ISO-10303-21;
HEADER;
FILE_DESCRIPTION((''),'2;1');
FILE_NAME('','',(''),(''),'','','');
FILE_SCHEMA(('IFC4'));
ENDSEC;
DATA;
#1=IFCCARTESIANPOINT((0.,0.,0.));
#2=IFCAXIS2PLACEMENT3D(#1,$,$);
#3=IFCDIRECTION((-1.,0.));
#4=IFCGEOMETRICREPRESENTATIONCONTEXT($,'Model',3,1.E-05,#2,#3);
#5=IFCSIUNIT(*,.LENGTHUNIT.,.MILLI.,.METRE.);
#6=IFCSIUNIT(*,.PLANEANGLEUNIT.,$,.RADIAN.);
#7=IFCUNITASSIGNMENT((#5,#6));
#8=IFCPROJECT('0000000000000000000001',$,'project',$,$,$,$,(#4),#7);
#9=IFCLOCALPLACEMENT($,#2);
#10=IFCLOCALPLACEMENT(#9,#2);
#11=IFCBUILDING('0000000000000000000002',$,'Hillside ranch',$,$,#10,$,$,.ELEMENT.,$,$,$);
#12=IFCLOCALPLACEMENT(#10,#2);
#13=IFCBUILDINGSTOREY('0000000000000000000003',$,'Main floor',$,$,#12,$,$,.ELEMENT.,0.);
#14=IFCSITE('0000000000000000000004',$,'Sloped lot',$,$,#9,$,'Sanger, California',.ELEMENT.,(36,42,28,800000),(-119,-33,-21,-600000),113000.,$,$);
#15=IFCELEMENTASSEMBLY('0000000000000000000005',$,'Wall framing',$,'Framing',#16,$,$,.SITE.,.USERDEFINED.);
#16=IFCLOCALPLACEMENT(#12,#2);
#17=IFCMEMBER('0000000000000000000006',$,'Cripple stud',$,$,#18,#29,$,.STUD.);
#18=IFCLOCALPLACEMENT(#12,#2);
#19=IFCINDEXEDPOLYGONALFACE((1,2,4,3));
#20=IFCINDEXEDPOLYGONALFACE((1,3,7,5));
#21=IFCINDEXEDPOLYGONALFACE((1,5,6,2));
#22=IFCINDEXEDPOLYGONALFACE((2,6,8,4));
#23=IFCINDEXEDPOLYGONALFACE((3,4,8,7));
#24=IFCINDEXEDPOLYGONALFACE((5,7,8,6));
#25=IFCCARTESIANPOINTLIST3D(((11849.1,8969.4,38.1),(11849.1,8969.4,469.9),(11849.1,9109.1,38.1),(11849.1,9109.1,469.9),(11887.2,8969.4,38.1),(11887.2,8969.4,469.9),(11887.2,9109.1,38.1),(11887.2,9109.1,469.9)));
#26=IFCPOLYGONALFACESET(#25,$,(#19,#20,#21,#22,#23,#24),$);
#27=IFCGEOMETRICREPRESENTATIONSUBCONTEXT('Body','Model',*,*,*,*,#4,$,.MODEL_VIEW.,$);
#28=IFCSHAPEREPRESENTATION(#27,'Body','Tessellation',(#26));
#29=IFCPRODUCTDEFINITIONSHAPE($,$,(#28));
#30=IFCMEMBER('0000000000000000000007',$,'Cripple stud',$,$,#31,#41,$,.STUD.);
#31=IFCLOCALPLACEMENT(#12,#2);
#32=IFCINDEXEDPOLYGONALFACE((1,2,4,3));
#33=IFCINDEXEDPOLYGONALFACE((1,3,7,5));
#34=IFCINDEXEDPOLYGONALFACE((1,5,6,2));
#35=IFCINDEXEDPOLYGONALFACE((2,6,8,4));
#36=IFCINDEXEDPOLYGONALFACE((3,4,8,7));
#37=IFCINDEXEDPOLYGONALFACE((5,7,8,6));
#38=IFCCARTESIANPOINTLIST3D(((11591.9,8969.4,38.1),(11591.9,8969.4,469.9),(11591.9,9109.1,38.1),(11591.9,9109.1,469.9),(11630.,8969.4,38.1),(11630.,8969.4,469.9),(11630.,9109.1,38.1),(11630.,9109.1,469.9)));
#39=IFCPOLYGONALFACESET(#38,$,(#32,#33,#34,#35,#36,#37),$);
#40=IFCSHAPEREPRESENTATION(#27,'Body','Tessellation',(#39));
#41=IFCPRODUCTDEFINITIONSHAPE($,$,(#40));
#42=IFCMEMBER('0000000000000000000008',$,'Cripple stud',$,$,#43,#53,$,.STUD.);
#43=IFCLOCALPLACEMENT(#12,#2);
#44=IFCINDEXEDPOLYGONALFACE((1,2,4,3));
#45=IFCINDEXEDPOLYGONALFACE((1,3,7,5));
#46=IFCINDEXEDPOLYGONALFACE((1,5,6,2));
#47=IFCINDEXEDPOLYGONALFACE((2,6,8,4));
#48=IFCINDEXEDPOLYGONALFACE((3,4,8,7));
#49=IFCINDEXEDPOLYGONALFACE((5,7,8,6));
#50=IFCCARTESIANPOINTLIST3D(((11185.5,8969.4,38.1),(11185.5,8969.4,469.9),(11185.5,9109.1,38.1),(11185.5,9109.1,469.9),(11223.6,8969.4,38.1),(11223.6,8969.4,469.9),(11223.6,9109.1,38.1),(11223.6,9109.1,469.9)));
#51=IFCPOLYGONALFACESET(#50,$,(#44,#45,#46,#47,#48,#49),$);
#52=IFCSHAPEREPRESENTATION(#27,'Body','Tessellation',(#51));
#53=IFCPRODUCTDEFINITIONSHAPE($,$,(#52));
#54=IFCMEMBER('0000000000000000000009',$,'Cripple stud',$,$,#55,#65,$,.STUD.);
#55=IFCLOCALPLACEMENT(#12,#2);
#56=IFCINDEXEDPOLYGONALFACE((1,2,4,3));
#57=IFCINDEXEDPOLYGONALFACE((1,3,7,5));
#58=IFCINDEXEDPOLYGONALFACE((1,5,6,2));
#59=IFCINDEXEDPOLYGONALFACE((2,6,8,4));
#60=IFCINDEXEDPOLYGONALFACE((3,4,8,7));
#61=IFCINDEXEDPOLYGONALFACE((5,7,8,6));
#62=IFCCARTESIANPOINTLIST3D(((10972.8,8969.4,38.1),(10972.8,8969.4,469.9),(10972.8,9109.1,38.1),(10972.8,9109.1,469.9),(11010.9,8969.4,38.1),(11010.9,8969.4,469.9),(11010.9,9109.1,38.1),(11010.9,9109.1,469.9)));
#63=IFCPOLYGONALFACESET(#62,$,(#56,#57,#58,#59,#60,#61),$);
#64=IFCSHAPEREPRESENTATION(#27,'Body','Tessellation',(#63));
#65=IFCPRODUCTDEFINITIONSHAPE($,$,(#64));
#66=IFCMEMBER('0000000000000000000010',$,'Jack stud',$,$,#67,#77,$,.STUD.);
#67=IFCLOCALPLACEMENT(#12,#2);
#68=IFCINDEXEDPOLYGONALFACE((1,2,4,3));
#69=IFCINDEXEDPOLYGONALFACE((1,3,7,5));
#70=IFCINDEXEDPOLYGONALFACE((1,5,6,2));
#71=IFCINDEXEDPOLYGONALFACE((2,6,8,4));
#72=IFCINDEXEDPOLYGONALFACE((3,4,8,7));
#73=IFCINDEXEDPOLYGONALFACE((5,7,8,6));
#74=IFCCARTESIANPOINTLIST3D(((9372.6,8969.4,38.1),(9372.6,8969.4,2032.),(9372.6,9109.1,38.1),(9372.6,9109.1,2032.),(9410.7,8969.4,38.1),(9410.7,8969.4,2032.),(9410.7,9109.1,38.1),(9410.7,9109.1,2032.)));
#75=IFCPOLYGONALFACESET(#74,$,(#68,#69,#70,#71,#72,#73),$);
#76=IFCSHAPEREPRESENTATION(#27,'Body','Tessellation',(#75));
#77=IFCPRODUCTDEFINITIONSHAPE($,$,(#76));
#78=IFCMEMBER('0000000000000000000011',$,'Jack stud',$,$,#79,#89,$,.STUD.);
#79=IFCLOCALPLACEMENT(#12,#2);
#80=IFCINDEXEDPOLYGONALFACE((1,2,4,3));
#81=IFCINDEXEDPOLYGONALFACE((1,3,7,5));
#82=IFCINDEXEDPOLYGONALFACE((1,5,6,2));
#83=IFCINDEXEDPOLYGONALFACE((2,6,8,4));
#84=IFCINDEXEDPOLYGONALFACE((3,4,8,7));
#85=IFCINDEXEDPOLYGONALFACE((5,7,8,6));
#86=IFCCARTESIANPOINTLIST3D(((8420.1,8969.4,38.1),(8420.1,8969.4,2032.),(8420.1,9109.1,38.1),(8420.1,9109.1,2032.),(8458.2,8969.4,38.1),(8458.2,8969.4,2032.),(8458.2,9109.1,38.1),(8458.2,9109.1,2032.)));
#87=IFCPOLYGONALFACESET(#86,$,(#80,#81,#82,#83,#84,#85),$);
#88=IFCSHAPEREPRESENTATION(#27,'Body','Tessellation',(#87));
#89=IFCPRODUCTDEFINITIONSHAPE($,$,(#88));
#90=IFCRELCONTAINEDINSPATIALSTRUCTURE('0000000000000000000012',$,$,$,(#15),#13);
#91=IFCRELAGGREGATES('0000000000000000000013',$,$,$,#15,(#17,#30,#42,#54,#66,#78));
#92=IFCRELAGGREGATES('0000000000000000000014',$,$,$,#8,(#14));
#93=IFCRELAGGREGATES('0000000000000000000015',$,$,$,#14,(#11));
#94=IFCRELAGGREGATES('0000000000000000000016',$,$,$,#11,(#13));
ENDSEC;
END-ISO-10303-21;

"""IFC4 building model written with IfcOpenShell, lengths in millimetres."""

from ifc_helpers import new_model, si_unit, direction, frame, origin, origin_with_axes, place, context, subcontext, project, spatial, polyline, outline, extrude, element, aggregate, save


model = new_model("IFC4")

# Units and contexts
model_context = context("Model", 3, precision=1e-05, world=origin(), true_north=direction((-1.0, 0.0)))
body_context = subcontext(model_context, "Body", "Model", "MODEL_VIEW")
ifc_project = project(units=[si_unit("LENGTHUNIT", "METRE", prefix="MILLI"), si_unit("PLANEANGLEUNIT", "RADIAN")], contexts=[model_context])

# Site, building, storey
site_placement = place(None, origin())
site = spatial("IfcSite", under=ifc_project, at=site_placement, Name="Sloped lot", LongName="Sanger, California", CompositionType="ELEMENT", RefLatitude=(36, 42, 28, 800000), RefLongitude=(-119, -33, -21, -600000), RefElevation=113000.0)
building_placement = place(site_placement, origin())
building = spatial("IfcBuilding", under=site, at=building_placement, Name="Hillside ranch", CompositionType="ELEMENT")
storey_placement = place(building_placement, origin())
storey = spatial("IfcBuildingStorey", under=building, at=storey_placement, Name="Main floor", CompositionType="ELEMENT", Elevation=0.0)

# Element assembly, members
assembly_placement = place(storey_placement, origin_with_axes())
assembly = element("IfcElementAssembly", 1, at=assembly_placement, inside=storey, Name="Wall framing", ObjectType="Framing", AssemblyPlace="SITE", PredefinedType="USERDEFINED")
member_1_placement = place(storey_placement, origin_with_axes())
member_1 = element("IfcMember", 2, at=member_1_placement, Name="Cripple stud", PredefinedType="STUD", context=body_context, shape_type="SweptSolid", body=[
    extrude(outline(polyline([(0.0, 0.0), (38.1, 0.0), (38.1, 139.7), (0.0, 139.7), (0.0, 0.0)])), frame((11887.2, 9109.1, 38.1), z_axis=(0.0, 0.0, 1.0), x_axis=(-1.0, 0.0, 0.0)), (0.0, 0.0, 1.0), 431.8),
])
member_2_placement = place(storey_placement, origin_with_axes())
member_2 = element("IfcMember", 3, at=member_2_placement, Name="Cripple stud", PredefinedType="STUD", context=body_context, shape_type="SweptSolid", body=[
    extrude(outline(polyline([(0.0, 0.0), (38.1, 0.0), (38.1, 139.7), (0.0, 139.7), (0.0, 0.0)])), frame((11630.0, 9109.1, 38.1), z_axis=(0.0, 0.0, 1.0), x_axis=(-1.0, 0.0, 0.0)), (0.0, 0.0, 1.0), 431.8),
])
member_3_placement = place(storey_placement, origin_with_axes())
member_3 = element("IfcMember", 4, at=member_3_placement, Name="Cripple stud", PredefinedType="STUD", context=body_context, shape_type="SweptSolid", body=[
    extrude(outline(polyline([(0.0, 0.0), (38.1, 0.0), (38.1, 139.7), (0.0, 139.7), (0.0, 0.0)])), frame((11223.6, 9109.1, 38.1), z_axis=(0.0, 0.0, 1.0), x_axis=(-1.0, 0.0, 0.0)), (0.0, 0.0, 1.0), 431.8),
])
member_4_placement = place(storey_placement, origin_with_axes())
member_4 = element("IfcMember", 5, at=member_4_placement, Name="Cripple stud", PredefinedType="STUD", context=body_context, shape_type="SweptSolid", body=[
    extrude(outline(polyline([(0.0, 0.0), (38.1, 0.0), (38.1, 139.7), (0.0, 139.7), (0.0, 0.0)])), frame((11010.9, 9109.1, 38.1), z_axis=(0.0, 0.0, 1.0), x_axis=(-1.0, 0.0, 0.0)), (0.0, 0.0, 1.0), 431.8),
])
member_5_placement = place(storey_placement, origin_with_axes())
member_5 = element("IfcMember", 6, at=member_5_placement, Name="Jack stud", PredefinedType="STUD", context=body_context, shape_type="SweptSolid", body=[
    extrude(outline(polyline([(0.0, 0.0), (38.1, 0.0), (38.1, 139.7), (0.0, 139.7), (0.0, 0.0)])), frame((9410.7, 9109.1, 38.1), z_axis=(0.0, 0.0, 1.0), x_axis=(-1.0, 0.0, 0.0)), (0.0, 0.0, 1.0), 1993.9),
])
member_6_placement = place(storey_placement, origin_with_axes())
member_6 = element("IfcMember", 7, at=member_6_placement, Name="Jack stud", PredefinedType="STUD", context=body_context, shape_type="SweptSolid", body=[
    extrude(outline(polyline([(0.0, 0.0), (38.1, 0.0), (38.1, 139.7), (0.0, 139.7), (0.0, 0.0)])), frame((8458.2, 9109.1, 38.1), z_axis=(0.0, 0.0, 1.0), x_axis=(-1.0, 0.0, 0.0)), (0.0, 0.0, 1.0), 1993.9),
])
aggregate(assembly, [member_1, member_2, member_3, member_4, member_5, member_6])

save(model, "model.ifc")
